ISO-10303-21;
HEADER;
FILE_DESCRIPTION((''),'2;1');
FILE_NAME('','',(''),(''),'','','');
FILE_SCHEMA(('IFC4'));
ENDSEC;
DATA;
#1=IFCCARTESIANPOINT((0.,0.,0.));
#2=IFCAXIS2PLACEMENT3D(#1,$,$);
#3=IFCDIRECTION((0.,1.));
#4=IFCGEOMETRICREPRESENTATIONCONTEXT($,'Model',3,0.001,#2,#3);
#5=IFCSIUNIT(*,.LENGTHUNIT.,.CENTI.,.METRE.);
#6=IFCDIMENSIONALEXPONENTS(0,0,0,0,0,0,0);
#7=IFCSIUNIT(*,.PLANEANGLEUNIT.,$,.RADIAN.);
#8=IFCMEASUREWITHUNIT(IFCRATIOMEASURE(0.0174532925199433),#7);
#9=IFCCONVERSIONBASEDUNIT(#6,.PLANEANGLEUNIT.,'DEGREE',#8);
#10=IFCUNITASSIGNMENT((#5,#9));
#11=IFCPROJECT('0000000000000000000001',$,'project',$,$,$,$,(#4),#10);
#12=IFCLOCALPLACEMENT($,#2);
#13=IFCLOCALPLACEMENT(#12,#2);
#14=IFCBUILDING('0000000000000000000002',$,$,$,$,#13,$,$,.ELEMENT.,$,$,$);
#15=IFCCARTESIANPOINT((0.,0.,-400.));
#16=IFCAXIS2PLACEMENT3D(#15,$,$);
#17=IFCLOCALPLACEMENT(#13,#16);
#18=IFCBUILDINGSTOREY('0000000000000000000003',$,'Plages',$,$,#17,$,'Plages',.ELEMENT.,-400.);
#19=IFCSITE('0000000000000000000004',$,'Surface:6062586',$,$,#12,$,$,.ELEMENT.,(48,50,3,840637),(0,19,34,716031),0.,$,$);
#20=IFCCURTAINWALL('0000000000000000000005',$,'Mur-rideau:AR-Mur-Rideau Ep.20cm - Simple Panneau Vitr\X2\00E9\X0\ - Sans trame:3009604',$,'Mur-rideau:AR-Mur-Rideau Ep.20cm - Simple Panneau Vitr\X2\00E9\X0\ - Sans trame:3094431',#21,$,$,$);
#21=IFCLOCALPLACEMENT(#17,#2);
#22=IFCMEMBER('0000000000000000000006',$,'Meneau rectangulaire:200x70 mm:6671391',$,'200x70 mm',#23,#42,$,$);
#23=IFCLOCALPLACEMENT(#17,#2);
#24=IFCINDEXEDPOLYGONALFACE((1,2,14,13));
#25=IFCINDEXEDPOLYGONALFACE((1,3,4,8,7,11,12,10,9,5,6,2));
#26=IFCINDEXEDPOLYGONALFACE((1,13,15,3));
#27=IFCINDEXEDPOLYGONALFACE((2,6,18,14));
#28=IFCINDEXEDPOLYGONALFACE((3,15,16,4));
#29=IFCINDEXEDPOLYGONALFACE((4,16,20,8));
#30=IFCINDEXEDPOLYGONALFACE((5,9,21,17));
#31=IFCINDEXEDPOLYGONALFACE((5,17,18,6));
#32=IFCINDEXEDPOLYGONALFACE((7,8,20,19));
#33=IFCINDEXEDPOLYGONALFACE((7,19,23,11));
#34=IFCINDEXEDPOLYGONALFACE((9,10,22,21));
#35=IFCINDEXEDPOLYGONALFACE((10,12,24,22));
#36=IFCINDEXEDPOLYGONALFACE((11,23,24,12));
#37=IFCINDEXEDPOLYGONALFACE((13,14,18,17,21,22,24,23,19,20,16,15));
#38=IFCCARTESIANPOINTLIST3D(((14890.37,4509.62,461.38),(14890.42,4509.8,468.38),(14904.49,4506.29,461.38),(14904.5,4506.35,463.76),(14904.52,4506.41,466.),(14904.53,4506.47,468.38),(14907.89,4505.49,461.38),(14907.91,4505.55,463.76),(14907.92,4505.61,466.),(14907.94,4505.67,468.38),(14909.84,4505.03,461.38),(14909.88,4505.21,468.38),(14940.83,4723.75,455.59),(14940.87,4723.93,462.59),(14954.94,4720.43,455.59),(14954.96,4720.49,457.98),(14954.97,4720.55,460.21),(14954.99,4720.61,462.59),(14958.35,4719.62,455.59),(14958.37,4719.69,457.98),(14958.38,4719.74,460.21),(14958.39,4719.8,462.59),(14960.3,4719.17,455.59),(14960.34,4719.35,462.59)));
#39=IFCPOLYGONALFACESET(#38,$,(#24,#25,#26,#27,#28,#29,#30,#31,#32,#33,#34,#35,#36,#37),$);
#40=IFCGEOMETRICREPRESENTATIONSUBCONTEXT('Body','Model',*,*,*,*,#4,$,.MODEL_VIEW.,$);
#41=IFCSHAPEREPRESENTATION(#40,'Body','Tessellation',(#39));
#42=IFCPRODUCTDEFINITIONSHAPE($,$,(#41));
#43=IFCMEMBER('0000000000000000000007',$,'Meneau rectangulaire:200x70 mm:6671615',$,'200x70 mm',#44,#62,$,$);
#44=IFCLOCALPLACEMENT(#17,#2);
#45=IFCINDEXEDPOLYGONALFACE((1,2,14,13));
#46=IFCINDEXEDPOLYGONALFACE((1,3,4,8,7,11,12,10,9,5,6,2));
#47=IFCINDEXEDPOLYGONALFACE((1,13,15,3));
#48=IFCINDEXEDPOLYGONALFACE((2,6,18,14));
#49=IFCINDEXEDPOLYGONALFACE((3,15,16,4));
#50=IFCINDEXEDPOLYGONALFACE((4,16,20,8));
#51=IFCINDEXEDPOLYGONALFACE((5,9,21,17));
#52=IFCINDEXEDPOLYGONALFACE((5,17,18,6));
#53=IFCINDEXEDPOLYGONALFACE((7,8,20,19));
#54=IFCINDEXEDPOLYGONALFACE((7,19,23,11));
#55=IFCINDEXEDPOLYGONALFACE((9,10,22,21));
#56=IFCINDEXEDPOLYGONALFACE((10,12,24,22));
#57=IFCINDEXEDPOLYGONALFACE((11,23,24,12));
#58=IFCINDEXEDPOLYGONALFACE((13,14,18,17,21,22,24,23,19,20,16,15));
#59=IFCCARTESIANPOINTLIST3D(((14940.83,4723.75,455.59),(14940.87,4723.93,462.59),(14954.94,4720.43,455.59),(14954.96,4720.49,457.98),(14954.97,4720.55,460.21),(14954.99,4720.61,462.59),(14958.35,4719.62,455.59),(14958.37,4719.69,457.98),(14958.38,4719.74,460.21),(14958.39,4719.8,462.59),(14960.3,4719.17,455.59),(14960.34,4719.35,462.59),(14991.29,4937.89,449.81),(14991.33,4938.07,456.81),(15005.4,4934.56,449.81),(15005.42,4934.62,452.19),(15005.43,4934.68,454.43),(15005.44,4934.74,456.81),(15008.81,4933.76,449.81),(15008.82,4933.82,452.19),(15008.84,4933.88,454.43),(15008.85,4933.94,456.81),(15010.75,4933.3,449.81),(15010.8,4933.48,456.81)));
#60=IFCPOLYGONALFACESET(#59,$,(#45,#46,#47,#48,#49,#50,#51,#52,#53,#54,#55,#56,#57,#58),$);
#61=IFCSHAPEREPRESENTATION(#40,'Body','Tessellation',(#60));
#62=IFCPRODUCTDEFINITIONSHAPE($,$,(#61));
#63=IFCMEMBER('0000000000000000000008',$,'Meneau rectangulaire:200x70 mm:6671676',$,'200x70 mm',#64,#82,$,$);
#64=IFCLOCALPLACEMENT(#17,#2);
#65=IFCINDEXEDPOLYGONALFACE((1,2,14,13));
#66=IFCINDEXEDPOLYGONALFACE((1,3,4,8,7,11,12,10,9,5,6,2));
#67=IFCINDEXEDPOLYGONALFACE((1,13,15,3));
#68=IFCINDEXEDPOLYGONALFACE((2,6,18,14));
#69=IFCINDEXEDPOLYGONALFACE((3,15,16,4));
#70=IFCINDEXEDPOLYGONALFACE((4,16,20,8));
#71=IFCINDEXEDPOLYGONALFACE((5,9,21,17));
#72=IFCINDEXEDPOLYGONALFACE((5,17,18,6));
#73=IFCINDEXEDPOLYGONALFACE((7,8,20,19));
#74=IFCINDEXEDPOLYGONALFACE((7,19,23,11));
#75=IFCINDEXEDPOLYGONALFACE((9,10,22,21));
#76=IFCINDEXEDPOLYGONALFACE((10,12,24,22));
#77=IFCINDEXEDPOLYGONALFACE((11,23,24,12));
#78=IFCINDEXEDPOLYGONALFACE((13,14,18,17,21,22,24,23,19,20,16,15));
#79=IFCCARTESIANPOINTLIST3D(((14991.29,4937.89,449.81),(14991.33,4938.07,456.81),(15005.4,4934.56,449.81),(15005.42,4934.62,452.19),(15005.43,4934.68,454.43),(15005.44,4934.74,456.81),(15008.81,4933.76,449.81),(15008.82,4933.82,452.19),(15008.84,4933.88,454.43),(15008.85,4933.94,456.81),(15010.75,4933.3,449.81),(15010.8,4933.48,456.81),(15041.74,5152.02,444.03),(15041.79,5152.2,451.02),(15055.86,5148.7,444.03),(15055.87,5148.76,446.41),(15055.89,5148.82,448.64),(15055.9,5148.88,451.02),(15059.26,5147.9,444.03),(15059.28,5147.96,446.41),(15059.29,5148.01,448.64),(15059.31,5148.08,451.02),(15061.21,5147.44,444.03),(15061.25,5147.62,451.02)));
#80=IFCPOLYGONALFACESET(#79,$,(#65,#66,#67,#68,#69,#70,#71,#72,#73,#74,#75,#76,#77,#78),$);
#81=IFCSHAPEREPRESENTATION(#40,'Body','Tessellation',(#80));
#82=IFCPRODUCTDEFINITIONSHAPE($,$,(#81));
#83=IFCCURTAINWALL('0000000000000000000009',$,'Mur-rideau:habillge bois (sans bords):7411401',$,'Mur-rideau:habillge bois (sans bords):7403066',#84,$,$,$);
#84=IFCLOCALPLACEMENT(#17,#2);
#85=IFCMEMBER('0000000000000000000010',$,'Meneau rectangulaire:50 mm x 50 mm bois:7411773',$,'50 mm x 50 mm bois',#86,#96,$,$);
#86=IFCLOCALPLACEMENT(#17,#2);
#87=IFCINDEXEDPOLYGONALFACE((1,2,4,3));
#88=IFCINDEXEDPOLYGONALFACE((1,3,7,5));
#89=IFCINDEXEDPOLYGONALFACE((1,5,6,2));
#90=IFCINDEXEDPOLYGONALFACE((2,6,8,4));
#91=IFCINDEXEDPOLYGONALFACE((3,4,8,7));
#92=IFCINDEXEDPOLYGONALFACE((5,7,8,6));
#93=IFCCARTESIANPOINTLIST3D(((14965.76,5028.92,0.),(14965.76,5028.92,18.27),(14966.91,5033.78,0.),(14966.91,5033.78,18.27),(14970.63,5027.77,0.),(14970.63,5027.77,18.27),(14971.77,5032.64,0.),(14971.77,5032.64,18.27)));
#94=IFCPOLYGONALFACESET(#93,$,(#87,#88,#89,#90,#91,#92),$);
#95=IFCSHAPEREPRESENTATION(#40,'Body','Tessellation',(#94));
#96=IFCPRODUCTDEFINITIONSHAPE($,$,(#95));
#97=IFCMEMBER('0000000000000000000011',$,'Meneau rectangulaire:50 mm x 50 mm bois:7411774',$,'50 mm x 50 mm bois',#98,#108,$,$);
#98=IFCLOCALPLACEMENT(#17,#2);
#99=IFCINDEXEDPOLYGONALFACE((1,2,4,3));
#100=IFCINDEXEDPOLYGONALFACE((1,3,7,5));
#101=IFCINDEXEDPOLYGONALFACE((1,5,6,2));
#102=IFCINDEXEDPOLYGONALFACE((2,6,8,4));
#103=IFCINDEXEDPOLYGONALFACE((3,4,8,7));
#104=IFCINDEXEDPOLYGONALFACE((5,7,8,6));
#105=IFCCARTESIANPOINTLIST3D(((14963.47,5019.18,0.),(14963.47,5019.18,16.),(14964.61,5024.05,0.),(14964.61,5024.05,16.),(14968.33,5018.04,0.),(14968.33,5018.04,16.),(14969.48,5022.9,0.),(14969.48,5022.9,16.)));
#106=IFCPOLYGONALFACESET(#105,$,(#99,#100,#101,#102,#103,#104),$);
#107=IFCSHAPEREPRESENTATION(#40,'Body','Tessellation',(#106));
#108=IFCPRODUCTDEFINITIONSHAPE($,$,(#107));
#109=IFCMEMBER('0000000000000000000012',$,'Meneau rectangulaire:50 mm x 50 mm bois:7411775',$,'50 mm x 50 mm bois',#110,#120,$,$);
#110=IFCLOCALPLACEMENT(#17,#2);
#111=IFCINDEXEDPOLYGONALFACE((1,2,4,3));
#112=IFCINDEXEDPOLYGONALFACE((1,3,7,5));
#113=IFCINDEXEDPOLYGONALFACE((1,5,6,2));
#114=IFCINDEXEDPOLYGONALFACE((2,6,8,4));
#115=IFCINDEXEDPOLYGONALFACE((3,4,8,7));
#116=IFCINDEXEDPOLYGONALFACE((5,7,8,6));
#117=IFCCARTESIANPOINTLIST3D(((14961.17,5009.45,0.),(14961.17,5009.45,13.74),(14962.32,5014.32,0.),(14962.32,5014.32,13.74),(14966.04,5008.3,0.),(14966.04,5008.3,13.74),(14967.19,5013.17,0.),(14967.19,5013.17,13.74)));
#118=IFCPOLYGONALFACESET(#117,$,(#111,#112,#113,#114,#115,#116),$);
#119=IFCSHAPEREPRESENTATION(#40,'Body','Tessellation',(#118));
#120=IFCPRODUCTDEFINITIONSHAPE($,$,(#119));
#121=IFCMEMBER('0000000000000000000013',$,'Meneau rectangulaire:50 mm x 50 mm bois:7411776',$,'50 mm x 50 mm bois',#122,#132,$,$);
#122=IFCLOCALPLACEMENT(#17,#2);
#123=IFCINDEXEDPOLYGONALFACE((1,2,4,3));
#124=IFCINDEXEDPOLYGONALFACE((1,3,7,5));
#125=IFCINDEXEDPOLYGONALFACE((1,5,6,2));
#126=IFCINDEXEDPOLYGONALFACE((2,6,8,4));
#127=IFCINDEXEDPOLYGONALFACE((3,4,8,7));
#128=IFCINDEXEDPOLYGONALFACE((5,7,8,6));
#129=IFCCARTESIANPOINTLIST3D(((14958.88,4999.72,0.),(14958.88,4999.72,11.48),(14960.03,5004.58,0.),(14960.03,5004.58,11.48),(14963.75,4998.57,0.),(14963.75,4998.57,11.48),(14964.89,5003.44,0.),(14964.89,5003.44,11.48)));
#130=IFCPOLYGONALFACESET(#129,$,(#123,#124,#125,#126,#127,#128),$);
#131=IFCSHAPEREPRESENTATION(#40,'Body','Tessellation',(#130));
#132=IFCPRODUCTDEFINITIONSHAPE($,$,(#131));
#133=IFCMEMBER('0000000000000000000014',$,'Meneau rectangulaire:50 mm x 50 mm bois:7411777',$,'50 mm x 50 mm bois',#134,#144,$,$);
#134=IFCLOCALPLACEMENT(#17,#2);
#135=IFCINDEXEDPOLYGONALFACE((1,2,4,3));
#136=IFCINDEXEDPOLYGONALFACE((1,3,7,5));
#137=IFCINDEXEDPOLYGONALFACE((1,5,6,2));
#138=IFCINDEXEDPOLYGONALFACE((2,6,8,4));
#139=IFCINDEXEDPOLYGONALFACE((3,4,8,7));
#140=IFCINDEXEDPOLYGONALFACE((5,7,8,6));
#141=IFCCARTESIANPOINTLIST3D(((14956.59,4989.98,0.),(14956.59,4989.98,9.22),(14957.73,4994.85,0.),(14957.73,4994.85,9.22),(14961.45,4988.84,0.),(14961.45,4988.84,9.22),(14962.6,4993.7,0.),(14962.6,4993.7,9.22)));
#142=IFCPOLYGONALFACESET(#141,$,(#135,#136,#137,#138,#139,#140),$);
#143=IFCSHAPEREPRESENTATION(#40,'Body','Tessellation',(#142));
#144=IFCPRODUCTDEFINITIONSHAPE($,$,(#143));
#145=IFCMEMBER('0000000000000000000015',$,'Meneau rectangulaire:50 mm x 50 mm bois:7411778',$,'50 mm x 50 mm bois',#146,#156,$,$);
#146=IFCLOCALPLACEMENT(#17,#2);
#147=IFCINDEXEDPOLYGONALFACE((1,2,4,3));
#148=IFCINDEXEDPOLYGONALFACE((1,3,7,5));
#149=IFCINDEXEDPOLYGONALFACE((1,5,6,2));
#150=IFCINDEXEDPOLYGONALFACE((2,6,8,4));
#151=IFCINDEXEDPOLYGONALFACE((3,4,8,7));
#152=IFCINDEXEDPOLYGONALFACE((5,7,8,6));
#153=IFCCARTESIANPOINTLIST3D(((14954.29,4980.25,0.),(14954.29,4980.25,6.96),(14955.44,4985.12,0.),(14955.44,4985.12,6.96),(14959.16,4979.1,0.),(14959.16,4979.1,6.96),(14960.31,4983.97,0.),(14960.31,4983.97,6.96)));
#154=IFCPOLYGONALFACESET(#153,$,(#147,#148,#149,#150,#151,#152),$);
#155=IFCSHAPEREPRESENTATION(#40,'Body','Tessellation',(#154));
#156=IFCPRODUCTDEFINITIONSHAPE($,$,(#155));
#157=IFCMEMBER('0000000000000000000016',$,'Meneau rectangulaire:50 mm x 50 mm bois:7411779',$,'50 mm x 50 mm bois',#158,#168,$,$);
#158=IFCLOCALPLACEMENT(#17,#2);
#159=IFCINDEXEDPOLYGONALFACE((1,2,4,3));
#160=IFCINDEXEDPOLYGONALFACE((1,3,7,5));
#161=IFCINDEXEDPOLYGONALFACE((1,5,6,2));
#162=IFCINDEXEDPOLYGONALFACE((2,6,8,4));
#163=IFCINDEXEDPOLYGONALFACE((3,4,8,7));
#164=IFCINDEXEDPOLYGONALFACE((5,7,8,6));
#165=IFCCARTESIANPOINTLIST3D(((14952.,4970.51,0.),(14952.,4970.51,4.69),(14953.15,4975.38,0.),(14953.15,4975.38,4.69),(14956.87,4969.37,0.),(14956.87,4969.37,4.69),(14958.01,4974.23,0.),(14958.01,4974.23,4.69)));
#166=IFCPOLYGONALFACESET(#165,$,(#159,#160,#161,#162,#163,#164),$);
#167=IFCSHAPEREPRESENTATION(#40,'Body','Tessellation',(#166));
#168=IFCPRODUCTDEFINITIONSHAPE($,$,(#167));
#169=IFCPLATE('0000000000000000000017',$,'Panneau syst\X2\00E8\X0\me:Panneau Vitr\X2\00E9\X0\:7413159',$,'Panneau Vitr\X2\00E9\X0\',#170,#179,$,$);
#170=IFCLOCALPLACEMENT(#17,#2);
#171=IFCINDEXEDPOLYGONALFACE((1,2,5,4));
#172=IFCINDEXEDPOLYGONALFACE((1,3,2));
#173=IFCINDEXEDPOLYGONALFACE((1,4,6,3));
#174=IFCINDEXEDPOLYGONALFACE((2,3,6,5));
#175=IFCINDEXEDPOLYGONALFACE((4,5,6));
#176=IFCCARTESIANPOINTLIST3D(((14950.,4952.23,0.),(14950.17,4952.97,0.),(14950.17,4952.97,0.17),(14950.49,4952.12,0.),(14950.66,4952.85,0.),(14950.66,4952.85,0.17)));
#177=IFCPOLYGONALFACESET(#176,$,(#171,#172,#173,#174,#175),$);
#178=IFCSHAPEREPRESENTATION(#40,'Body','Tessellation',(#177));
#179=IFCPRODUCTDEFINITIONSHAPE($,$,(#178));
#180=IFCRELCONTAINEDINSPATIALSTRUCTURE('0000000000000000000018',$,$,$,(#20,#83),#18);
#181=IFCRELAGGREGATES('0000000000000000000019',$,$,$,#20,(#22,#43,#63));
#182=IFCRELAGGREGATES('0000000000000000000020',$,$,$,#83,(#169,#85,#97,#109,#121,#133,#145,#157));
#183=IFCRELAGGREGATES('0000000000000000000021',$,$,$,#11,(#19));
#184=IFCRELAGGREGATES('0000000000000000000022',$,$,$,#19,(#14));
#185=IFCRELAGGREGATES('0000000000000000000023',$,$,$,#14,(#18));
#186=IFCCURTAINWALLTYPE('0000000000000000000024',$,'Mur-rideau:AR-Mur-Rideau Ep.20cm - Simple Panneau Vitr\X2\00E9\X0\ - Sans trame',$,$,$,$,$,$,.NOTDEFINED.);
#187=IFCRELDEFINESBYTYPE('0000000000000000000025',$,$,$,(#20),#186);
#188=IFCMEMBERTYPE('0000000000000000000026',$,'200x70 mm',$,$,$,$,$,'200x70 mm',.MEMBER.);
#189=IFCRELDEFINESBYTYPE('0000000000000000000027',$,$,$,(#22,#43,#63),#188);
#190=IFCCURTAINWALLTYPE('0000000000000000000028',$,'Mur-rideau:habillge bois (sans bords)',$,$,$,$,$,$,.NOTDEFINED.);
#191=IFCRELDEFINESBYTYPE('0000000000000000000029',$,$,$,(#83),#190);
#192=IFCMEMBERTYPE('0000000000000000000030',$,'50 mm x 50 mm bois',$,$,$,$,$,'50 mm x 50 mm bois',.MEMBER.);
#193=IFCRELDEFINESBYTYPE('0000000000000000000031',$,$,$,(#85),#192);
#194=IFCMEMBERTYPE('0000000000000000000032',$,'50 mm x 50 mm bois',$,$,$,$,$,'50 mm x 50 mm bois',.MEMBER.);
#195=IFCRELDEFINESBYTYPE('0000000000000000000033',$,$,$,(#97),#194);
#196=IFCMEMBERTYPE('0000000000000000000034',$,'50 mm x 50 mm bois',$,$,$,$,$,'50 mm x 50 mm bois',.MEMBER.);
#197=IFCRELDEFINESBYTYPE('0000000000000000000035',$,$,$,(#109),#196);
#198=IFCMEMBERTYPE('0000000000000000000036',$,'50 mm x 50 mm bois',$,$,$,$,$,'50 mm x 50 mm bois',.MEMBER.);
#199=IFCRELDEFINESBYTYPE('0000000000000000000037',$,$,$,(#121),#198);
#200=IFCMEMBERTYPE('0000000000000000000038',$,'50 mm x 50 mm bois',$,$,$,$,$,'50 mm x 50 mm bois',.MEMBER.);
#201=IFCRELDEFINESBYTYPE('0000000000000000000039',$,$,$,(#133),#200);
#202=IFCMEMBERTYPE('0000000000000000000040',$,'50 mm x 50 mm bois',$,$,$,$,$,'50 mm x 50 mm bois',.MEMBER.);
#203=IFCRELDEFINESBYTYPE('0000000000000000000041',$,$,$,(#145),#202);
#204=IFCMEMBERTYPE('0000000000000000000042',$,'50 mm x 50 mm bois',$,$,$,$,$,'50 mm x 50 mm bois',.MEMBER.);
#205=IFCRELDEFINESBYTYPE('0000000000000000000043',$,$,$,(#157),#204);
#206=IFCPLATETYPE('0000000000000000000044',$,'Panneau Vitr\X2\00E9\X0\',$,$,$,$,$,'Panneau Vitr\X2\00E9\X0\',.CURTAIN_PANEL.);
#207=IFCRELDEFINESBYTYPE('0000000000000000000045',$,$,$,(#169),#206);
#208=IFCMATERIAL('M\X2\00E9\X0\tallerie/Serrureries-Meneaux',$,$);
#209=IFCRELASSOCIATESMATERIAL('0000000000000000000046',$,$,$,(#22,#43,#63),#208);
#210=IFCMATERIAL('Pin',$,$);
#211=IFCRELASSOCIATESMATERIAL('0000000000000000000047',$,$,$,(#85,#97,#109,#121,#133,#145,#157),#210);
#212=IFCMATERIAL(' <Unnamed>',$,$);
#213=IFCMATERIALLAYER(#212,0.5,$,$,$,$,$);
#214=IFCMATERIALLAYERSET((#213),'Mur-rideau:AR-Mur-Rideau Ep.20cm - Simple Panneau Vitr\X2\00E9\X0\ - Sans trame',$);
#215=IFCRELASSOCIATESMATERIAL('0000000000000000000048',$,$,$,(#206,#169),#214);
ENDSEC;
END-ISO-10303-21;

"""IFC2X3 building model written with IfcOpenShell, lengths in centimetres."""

from ifc_helpers import new_model, entity, si_unit, converted_unit, direction, frame, origin, origin_2d_with_axis, place, context, subcontext, project, spatial, polyline, rectangle, outline, extrude, source, transform, mapped, material, layer, layer_set, layer_usage, type_object, type_shapes, element, aggregate, save


model = new_model("IFC2X3")

# Units and contexts
model_context = context("Model", 3, precision=0.001, world=origin(), true_north=direction((0.0, 1.0)))
body_context = subcontext(model_context, "Body", "Model", "MODEL_VIEW")
ifc_project = project(units=[si_unit("LENGTHUNIT", "METRE", prefix="CENTI"), converted_unit("PLANEANGLEUNIT", "DEGREE", entity("IfcRatioMeasure", 0.0174532925199433), si_unit("PLANEANGLEUNIT", "RADIAN"), dimensions=[0, 0, 0, 0, 0, 0, 0])], contexts=[model_context])

# Site, building, storey
site_placement = place(None, origin())
site = spatial("IfcSite", under=ifc_project, at=site_placement, Name="Surface:6062586", CompositionType="ELEMENT", RefLatitude=(48, 50, 3, 840637), RefLongitude=(0, 19, 34, 716031), RefElevation=0.0)
building_placement = place(site_placement, origin())
building = spatial("IfcBuilding", under=site, at=building_placement, CompositionType="ELEMENT")
storey_placement = place(building_placement, frame((0.0, 0.0, -400.0)))
storey = spatial("IfcBuildingStorey", under=building, at=storey_placement, Name="Plages", LongName="Plages", CompositionType="ELEMENT", Elevation=-400.0)

# Curtain walls, members
curtain_wall_type_1 = type_object("IfcCurtainWallType", Name="Mur-rideau:AR-Mur-Rideau Ep.20cm - Simple Panneau Vitré - Sans trame", PredefinedType="NOTDEFINED")
curtain_wall_1_placement = place(storey_placement, frame((0.0, 0.0, 400.0)))
curtain_wall_1 = element("IfcCurtainWall", 1, at=curtain_wall_1_placement, inside=storey, type_object=curtain_wall_type_1, Name="Mur-rideau:AR-Mur-Rideau Ep.20cm - Simple Panneau Vitré - Sans trame:3009604", ObjectType="Mur-rideau:AR-Mur-Rideau Ep.20cm - Simple Panneau Vitré - Sans trame:3094431")
ifc_material_1 = material(Name="Métallerie/Serrureries-Meneaux")
member_type_1 = type_object("IfcMemberType", Name="200x70 mm", ElementType="200x70 mm", PredefinedType="MEMBER")
shared_shape_1 = source(origin(), body_context, "Body", "SweptSolid", [
    extrude(outline(polyline([(-14.17, -3.5), (0.33, -3.5), (0.33, -1.12), (3.83, -1.12), (3.83, -3.5), (5.83, -3.5), (5.83, 3.5), (3.83, 3.5), (3.83, 1.12), (0.33, 1.12), (0.33, 3.5), (-14.17, 3.5), (-14.17, -3.5)])), frame((-3.5, 2.08, -220.08), z_axis=(0.0, 0.0, 1.0), x_axis=(0.0, -1.0, 0.0)), (0.0, 0.0, 1.0), 220.08),
])
type_shapes(member_type_1, [shared_shape_1])
member_1_placement = place(storey_placement, frame((14906.23, 4506.07, 468.38), z_axis=(-0.229269, -0.973008, 0.026282), x_axis=(0.006028, 0.025581, 0.999655)))
member_1 = element("IfcMember", 2, at=member_1_placement, type_object=member_type_1, material=ifc_material_1, Name="Meneau rectangulaire:200x70 mm:6671391", ObjectType="200x70 mm", context=body_context, shape_type="MappedRepresentation", body=[
    mapped(shared_shape_1, transform((0.0, 0.0, 0.0), scale=1.0)),
])
member_2_placement = place(storey_placement, frame((14956.69, 4720.21, 462.59), z_axis=(-0.229269, -0.973008, 0.026282), x_axis=(0.006028, 0.025581, 0.999655)))
member_2 = element("IfcMember", 3, at=member_2_placement, type_object=member_type_1, material=ifc_material_1, Name="Meneau rectangulaire:200x70 mm:6671615", ObjectType="200x70 mm", context=body_context, shape_type="MappedRepresentation", body=[
    mapped(shared_shape_1, transform((0.0, 0.0, 0.0), scale=1.0)),
])
member_3_placement = place(storey_placement, frame((15007.15, 4934.34, 456.81), z_axis=(-0.229269, -0.973008, 0.026282), x_axis=(0.006028, 0.025581, 0.999655)))
member_3 = element("IfcMember", 4, at=member_3_placement, type_object=member_type_1, material=ifc_material_1, Name="Meneau rectangulaire:200x70 mm:6671676", ObjectType="200x70 mm", context=body_context, shape_type="MappedRepresentation", body=[
    mapped(shared_shape_1, transform((0.0, 0.0, 0.0), scale=1.0)),
])
curtain_wall_type_2 = type_object("IfcCurtainWallType", Name="Mur-rideau:habillge bois (sans bords)", PredefinedType="NOTDEFINED")
curtain_wall_2_placement = place(storey_placement, frame((0.0, 0.0, 400.0)))
curtain_wall_2 = element("IfcCurtainWall", 5, at=curtain_wall_2_placement, inside=storey, type_object=curtain_wall_type_2, Name="Mur-rideau:habillge bois (sans bords):7411401", ObjectType="Mur-rideau:habillge bois (sans bords):7403066")
ifc_material_2 = material(Name="Pin")
member_type_2 = type_object("IfcMemberType", Name="50 mm x 50 mm bois", ElementType="50 mm x 50 mm bois", PredefinedType="MEMBER")
shared_shape_2 = source(origin(), body_context, "Body", "SweptSolid", [
    extrude(rectangle(XDim=5.0, YDim=5.0, at=origin_2d_with_axis()), frame((0.0, 0.0, -18.27), z_axis=(0.0, 0.0, 1.0), x_axis=(0.0, -1.0, 0.0)), (0.0, 0.0, 1.0), 18.27),
])
type_shapes(member_type_2, [shared_shape_2])
member_4_placement = place(storey_placement, frame((14968.77, 5030.78, 0.0), z_axis=(0.0, 0.0, -1.0), x_axis=(-0.229349, -0.973344, 0.0)))
member_4 = element("IfcMember", 6, at=member_4_placement, type_object=member_type_2, material=ifc_material_2, Name="Meneau rectangulaire:50 mm x 50 mm bois:7411773", ObjectType="50 mm x 50 mm bois", context=body_context, shape_type="MappedRepresentation", body=[
    mapped(shared_shape_2, transform((0.0, 0.0, 0.0), scale=1.0)),
])
member_type_3 = type_object("IfcMemberType", Name="50 mm x 50 mm bois", ElementType="50 mm x 50 mm bois", PredefinedType="MEMBER")
shared_shape_3 = source(origin(), body_context, "Body", "SweptSolid", [
    extrude(rectangle(XDim=5.0, YDim=5.0, at=origin_2d_with_axis()), frame((0.0, 0.0, -16.0), z_axis=(0.0, 0.0, 1.0), x_axis=(0.0, -1.0, 0.0)), (0.0, 0.0, 1.0), 16.0),
])
type_shapes(member_type_3, [shared_shape_3])
member_5_placement = place(storey_placement, frame((14966.47, 5021.04, 0.0), z_axis=(0.0, 0.0, -1.0), x_axis=(-0.229349, -0.973344, 0.0)))
member_5 = element("IfcMember", 7, at=member_5_placement, type_object=member_type_3, material=ifc_material_2, Name="Meneau rectangulaire:50 mm x 50 mm bois:7411774", ObjectType="50 mm x 50 mm bois", context=body_context, shape_type="MappedRepresentation", body=[
    mapped(shared_shape_3, transform((0.0, 0.0, 0.0), scale=1.0)),
])
member_type_4 = type_object("IfcMemberType", Name="50 mm x 50 mm bois", ElementType="50 mm x 50 mm bois", PredefinedType="MEMBER")
shared_shape_4 = source(origin(), body_context, "Body", "SweptSolid", [
    extrude(rectangle(XDim=5.0, YDim=5.0, at=origin_2d_with_axis()), frame((0.0, 0.0, -13.74), z_axis=(0.0, 0.0, 1.0), x_axis=(0.0, -1.0, 0.0)), (0.0, 0.0, 1.0), 13.74),
])
type_shapes(member_type_4, [shared_shape_4])
member_6_placement = place(storey_placement, frame((14964.18, 5011.31, 0.0), z_axis=(0.0, 0.0, -1.0), x_axis=(-0.229349, -0.973344, 0.0)))
member_6 = element("IfcMember", 8, at=member_6_placement, type_object=member_type_4, material=ifc_material_2, Name="Meneau rectangulaire:50 mm x 50 mm bois:7411775", ObjectType="50 mm x 50 mm bois", context=body_context, shape_type="MappedRepresentation", body=[
    mapped(shared_shape_4, transform((0.0, 0.0, 0.0), scale=1.0)),
])
member_type_5 = type_object("IfcMemberType", Name="50 mm x 50 mm bois", ElementType="50 mm x 50 mm bois", PredefinedType="MEMBER")
shared_shape_5 = source(origin(), body_context, "Body", "SweptSolid", [
    extrude(rectangle(XDim=5.0, YDim=5.0, at=origin_2d_with_axis()), frame((0.0, 0.0, -11.48), z_axis=(0.0, 0.0, 1.0), x_axis=(0.0, -1.0, 0.0)), (0.0, 0.0, 1.0), 11.48),
])
type_shapes(member_type_5, [shared_shape_5])
member_7_placement = place(storey_placement, frame((14961.89, 5001.58, 0.0), z_axis=(0.0, 0.0, -1.0), x_axis=(-0.229349, -0.973344, 0.0)))
member_7 = element("IfcMember", 9, at=member_7_placement, type_object=member_type_5, material=ifc_material_2, Name="Meneau rectangulaire:50 mm x 50 mm bois:7411776", ObjectType="50 mm x 50 mm bois", context=body_context, shape_type="MappedRepresentation", body=[
    mapped(shared_shape_5, transform((0.0, 0.0, 0.0), scale=1.0)),
])
member_type_6 = type_object("IfcMemberType", Name="50 mm x 50 mm bois", ElementType="50 mm x 50 mm bois", PredefinedType="MEMBER")
shared_shape_6 = source(origin(), body_context, "Body", "SweptSolid", [
    extrude(rectangle(XDim=5.0, YDim=5.0, at=origin_2d_with_axis()), frame((0.0, 0.0, -9.22), z_axis=(0.0, 0.0, 1.0), x_axis=(0.0, -1.0, 0.0)), (0.0, 0.0, 1.0), 9.22),
])
type_shapes(member_type_6, [shared_shape_6])
member_8_placement = place(storey_placement, frame((14959.59, 4991.84, 0.0), z_axis=(0.0, 0.0, -1.0), x_axis=(-0.229349, -0.973344, 0.0)))
member_8 = element("IfcMember", 10, at=member_8_placement, type_object=member_type_6, material=ifc_material_2, Name="Meneau rectangulaire:50 mm x 50 mm bois:7411777", ObjectType="50 mm x 50 mm bois", context=body_context, shape_type="MappedRepresentation", body=[
    mapped(shared_shape_6, transform((0.0, 0.0, 0.0), scale=1.0)),
])
member_type_7 = type_object("IfcMemberType", Name="50 mm x 50 mm bois", ElementType="50 mm x 50 mm bois", PredefinedType="MEMBER")
shared_shape_7 = source(origin(), body_context, "Body", "SweptSolid", [
    extrude(rectangle(XDim=5.0, YDim=5.0, at=origin_2d_with_axis()), frame((0.0, 0.0, -6.96), z_axis=(0.0, 0.0, 1.0), x_axis=(0.0, -1.0, 0.0)), (0.0, 0.0, 1.0), 6.96),
])
type_shapes(member_type_7, [shared_shape_7])
member_9_placement = place(storey_placement, frame((14957.3, 4982.11, 0.0), z_axis=(0.0, 0.0, -1.0), x_axis=(-0.229349, -0.973344, 0.0)))
member_9 = element("IfcMember", 11, at=member_9_placement, type_object=member_type_7, material=ifc_material_2, Name="Meneau rectangulaire:50 mm x 50 mm bois:7411778", ObjectType="50 mm x 50 mm bois", context=body_context, shape_type="MappedRepresentation", body=[
    mapped(shared_shape_7, transform((0.0, 0.0, 0.0), scale=1.0)),
])
member_type_8 = type_object("IfcMemberType", Name="50 mm x 50 mm bois", ElementType="50 mm x 50 mm bois", PredefinedType="MEMBER")
shared_shape_8 = source(origin(), body_context, "Body", "SweptSolid", [
    extrude(rectangle(XDim=5.0, YDim=5.0, at=origin_2d_with_axis()), frame((0.0, 0.0, -4.69), z_axis=(0.0, 0.0, 1.0), x_axis=(0.0, -1.0, 0.0)), (0.0, 0.0, 1.0), 4.69),
])
type_shapes(member_type_8, [shared_shape_8])
member_10_placement = place(storey_placement, frame((14955.01, 4972.37, 0.0), z_axis=(0.0, 0.0, -1.0), x_axis=(-0.229349, -0.973344, 0.0)))
member_10 = element("IfcMember", 12, at=member_10_placement, type_object=member_type_8, material=ifc_material_2, Name="Meneau rectangulaire:50 mm x 50 mm bois:7411779", ObjectType="50 mm x 50 mm bois", context=body_context, shape_type="MappedRepresentation", body=[
    mapped(shared_shape_8, transform((0.0, 0.0, 0.0), scale=1.0)),
])

# Shared definitions
ifc_material_3 = material(Name=" <Unnamed>")
aggregate(curtain_wall_1, [member_1, member_2, member_3])

# Plate
ifc_layer_1 = layer(ifc_material_3, 0.5)
ifc_layer_set_1 = layer_set([ifc_layer_1], Name="Mur-rideau:AR-Mur-Rideau Ep.20cm - Simple Panneau Vitré - Sans trame")
ifc_layer_usage_1 = layer_usage(ifc_layer_set_1, "AXIS3", "POSITIVE", 0.0)
plate_type_1 = type_object("IfcPlateType", Name="Panneau Vitré", ElementType="Panneau Vitré", PredefinedType="CURTAIN_PANEL", material=ifc_layer_set_1)
shared_shape_9 = source(origin(), body_context, "Body", "SweptSolid", [
    extrude(outline(polyline([(-0.06, -0.25), (0.11, -0.25), (-0.06, 0.5), (-0.06, -0.25)])), frame((-0.13, -0.25, 0.06), z_axis=(0.0, 1.0, 0.0), x_axis=(0.0, 0.0, 1.0)), (0.0, 0.0, 1.0), 0.5),
])
type_shapes(plate_type_1, [shared_shape_9])
plate_1_placement = place(curtain_wall_2_placement, frame((14950.33, 4952.54, -400.0), z_axis=(0.0, 0.0, 1.0), x_axis=(-0.229349, -0.973344, 0.0)))
plate_1 = element("IfcPlate", 13, at=plate_1_placement, type_object=plate_type_1, material=ifc_layer_usage_1, Name="Panneau système:Panneau Vitré:7413159", ObjectType="Panneau Vitré", context=body_context, shape_type="MappedRepresentation", body=[
    mapped(shared_shape_9, transform((0.0, 0.0, 0.0), scale=1.0)),
])
aggregate(curtain_wall_2, [plate_1, member_4, member_5, member_6, member_7, member_8, member_9, member_10])

save(model, "model.ifc")
